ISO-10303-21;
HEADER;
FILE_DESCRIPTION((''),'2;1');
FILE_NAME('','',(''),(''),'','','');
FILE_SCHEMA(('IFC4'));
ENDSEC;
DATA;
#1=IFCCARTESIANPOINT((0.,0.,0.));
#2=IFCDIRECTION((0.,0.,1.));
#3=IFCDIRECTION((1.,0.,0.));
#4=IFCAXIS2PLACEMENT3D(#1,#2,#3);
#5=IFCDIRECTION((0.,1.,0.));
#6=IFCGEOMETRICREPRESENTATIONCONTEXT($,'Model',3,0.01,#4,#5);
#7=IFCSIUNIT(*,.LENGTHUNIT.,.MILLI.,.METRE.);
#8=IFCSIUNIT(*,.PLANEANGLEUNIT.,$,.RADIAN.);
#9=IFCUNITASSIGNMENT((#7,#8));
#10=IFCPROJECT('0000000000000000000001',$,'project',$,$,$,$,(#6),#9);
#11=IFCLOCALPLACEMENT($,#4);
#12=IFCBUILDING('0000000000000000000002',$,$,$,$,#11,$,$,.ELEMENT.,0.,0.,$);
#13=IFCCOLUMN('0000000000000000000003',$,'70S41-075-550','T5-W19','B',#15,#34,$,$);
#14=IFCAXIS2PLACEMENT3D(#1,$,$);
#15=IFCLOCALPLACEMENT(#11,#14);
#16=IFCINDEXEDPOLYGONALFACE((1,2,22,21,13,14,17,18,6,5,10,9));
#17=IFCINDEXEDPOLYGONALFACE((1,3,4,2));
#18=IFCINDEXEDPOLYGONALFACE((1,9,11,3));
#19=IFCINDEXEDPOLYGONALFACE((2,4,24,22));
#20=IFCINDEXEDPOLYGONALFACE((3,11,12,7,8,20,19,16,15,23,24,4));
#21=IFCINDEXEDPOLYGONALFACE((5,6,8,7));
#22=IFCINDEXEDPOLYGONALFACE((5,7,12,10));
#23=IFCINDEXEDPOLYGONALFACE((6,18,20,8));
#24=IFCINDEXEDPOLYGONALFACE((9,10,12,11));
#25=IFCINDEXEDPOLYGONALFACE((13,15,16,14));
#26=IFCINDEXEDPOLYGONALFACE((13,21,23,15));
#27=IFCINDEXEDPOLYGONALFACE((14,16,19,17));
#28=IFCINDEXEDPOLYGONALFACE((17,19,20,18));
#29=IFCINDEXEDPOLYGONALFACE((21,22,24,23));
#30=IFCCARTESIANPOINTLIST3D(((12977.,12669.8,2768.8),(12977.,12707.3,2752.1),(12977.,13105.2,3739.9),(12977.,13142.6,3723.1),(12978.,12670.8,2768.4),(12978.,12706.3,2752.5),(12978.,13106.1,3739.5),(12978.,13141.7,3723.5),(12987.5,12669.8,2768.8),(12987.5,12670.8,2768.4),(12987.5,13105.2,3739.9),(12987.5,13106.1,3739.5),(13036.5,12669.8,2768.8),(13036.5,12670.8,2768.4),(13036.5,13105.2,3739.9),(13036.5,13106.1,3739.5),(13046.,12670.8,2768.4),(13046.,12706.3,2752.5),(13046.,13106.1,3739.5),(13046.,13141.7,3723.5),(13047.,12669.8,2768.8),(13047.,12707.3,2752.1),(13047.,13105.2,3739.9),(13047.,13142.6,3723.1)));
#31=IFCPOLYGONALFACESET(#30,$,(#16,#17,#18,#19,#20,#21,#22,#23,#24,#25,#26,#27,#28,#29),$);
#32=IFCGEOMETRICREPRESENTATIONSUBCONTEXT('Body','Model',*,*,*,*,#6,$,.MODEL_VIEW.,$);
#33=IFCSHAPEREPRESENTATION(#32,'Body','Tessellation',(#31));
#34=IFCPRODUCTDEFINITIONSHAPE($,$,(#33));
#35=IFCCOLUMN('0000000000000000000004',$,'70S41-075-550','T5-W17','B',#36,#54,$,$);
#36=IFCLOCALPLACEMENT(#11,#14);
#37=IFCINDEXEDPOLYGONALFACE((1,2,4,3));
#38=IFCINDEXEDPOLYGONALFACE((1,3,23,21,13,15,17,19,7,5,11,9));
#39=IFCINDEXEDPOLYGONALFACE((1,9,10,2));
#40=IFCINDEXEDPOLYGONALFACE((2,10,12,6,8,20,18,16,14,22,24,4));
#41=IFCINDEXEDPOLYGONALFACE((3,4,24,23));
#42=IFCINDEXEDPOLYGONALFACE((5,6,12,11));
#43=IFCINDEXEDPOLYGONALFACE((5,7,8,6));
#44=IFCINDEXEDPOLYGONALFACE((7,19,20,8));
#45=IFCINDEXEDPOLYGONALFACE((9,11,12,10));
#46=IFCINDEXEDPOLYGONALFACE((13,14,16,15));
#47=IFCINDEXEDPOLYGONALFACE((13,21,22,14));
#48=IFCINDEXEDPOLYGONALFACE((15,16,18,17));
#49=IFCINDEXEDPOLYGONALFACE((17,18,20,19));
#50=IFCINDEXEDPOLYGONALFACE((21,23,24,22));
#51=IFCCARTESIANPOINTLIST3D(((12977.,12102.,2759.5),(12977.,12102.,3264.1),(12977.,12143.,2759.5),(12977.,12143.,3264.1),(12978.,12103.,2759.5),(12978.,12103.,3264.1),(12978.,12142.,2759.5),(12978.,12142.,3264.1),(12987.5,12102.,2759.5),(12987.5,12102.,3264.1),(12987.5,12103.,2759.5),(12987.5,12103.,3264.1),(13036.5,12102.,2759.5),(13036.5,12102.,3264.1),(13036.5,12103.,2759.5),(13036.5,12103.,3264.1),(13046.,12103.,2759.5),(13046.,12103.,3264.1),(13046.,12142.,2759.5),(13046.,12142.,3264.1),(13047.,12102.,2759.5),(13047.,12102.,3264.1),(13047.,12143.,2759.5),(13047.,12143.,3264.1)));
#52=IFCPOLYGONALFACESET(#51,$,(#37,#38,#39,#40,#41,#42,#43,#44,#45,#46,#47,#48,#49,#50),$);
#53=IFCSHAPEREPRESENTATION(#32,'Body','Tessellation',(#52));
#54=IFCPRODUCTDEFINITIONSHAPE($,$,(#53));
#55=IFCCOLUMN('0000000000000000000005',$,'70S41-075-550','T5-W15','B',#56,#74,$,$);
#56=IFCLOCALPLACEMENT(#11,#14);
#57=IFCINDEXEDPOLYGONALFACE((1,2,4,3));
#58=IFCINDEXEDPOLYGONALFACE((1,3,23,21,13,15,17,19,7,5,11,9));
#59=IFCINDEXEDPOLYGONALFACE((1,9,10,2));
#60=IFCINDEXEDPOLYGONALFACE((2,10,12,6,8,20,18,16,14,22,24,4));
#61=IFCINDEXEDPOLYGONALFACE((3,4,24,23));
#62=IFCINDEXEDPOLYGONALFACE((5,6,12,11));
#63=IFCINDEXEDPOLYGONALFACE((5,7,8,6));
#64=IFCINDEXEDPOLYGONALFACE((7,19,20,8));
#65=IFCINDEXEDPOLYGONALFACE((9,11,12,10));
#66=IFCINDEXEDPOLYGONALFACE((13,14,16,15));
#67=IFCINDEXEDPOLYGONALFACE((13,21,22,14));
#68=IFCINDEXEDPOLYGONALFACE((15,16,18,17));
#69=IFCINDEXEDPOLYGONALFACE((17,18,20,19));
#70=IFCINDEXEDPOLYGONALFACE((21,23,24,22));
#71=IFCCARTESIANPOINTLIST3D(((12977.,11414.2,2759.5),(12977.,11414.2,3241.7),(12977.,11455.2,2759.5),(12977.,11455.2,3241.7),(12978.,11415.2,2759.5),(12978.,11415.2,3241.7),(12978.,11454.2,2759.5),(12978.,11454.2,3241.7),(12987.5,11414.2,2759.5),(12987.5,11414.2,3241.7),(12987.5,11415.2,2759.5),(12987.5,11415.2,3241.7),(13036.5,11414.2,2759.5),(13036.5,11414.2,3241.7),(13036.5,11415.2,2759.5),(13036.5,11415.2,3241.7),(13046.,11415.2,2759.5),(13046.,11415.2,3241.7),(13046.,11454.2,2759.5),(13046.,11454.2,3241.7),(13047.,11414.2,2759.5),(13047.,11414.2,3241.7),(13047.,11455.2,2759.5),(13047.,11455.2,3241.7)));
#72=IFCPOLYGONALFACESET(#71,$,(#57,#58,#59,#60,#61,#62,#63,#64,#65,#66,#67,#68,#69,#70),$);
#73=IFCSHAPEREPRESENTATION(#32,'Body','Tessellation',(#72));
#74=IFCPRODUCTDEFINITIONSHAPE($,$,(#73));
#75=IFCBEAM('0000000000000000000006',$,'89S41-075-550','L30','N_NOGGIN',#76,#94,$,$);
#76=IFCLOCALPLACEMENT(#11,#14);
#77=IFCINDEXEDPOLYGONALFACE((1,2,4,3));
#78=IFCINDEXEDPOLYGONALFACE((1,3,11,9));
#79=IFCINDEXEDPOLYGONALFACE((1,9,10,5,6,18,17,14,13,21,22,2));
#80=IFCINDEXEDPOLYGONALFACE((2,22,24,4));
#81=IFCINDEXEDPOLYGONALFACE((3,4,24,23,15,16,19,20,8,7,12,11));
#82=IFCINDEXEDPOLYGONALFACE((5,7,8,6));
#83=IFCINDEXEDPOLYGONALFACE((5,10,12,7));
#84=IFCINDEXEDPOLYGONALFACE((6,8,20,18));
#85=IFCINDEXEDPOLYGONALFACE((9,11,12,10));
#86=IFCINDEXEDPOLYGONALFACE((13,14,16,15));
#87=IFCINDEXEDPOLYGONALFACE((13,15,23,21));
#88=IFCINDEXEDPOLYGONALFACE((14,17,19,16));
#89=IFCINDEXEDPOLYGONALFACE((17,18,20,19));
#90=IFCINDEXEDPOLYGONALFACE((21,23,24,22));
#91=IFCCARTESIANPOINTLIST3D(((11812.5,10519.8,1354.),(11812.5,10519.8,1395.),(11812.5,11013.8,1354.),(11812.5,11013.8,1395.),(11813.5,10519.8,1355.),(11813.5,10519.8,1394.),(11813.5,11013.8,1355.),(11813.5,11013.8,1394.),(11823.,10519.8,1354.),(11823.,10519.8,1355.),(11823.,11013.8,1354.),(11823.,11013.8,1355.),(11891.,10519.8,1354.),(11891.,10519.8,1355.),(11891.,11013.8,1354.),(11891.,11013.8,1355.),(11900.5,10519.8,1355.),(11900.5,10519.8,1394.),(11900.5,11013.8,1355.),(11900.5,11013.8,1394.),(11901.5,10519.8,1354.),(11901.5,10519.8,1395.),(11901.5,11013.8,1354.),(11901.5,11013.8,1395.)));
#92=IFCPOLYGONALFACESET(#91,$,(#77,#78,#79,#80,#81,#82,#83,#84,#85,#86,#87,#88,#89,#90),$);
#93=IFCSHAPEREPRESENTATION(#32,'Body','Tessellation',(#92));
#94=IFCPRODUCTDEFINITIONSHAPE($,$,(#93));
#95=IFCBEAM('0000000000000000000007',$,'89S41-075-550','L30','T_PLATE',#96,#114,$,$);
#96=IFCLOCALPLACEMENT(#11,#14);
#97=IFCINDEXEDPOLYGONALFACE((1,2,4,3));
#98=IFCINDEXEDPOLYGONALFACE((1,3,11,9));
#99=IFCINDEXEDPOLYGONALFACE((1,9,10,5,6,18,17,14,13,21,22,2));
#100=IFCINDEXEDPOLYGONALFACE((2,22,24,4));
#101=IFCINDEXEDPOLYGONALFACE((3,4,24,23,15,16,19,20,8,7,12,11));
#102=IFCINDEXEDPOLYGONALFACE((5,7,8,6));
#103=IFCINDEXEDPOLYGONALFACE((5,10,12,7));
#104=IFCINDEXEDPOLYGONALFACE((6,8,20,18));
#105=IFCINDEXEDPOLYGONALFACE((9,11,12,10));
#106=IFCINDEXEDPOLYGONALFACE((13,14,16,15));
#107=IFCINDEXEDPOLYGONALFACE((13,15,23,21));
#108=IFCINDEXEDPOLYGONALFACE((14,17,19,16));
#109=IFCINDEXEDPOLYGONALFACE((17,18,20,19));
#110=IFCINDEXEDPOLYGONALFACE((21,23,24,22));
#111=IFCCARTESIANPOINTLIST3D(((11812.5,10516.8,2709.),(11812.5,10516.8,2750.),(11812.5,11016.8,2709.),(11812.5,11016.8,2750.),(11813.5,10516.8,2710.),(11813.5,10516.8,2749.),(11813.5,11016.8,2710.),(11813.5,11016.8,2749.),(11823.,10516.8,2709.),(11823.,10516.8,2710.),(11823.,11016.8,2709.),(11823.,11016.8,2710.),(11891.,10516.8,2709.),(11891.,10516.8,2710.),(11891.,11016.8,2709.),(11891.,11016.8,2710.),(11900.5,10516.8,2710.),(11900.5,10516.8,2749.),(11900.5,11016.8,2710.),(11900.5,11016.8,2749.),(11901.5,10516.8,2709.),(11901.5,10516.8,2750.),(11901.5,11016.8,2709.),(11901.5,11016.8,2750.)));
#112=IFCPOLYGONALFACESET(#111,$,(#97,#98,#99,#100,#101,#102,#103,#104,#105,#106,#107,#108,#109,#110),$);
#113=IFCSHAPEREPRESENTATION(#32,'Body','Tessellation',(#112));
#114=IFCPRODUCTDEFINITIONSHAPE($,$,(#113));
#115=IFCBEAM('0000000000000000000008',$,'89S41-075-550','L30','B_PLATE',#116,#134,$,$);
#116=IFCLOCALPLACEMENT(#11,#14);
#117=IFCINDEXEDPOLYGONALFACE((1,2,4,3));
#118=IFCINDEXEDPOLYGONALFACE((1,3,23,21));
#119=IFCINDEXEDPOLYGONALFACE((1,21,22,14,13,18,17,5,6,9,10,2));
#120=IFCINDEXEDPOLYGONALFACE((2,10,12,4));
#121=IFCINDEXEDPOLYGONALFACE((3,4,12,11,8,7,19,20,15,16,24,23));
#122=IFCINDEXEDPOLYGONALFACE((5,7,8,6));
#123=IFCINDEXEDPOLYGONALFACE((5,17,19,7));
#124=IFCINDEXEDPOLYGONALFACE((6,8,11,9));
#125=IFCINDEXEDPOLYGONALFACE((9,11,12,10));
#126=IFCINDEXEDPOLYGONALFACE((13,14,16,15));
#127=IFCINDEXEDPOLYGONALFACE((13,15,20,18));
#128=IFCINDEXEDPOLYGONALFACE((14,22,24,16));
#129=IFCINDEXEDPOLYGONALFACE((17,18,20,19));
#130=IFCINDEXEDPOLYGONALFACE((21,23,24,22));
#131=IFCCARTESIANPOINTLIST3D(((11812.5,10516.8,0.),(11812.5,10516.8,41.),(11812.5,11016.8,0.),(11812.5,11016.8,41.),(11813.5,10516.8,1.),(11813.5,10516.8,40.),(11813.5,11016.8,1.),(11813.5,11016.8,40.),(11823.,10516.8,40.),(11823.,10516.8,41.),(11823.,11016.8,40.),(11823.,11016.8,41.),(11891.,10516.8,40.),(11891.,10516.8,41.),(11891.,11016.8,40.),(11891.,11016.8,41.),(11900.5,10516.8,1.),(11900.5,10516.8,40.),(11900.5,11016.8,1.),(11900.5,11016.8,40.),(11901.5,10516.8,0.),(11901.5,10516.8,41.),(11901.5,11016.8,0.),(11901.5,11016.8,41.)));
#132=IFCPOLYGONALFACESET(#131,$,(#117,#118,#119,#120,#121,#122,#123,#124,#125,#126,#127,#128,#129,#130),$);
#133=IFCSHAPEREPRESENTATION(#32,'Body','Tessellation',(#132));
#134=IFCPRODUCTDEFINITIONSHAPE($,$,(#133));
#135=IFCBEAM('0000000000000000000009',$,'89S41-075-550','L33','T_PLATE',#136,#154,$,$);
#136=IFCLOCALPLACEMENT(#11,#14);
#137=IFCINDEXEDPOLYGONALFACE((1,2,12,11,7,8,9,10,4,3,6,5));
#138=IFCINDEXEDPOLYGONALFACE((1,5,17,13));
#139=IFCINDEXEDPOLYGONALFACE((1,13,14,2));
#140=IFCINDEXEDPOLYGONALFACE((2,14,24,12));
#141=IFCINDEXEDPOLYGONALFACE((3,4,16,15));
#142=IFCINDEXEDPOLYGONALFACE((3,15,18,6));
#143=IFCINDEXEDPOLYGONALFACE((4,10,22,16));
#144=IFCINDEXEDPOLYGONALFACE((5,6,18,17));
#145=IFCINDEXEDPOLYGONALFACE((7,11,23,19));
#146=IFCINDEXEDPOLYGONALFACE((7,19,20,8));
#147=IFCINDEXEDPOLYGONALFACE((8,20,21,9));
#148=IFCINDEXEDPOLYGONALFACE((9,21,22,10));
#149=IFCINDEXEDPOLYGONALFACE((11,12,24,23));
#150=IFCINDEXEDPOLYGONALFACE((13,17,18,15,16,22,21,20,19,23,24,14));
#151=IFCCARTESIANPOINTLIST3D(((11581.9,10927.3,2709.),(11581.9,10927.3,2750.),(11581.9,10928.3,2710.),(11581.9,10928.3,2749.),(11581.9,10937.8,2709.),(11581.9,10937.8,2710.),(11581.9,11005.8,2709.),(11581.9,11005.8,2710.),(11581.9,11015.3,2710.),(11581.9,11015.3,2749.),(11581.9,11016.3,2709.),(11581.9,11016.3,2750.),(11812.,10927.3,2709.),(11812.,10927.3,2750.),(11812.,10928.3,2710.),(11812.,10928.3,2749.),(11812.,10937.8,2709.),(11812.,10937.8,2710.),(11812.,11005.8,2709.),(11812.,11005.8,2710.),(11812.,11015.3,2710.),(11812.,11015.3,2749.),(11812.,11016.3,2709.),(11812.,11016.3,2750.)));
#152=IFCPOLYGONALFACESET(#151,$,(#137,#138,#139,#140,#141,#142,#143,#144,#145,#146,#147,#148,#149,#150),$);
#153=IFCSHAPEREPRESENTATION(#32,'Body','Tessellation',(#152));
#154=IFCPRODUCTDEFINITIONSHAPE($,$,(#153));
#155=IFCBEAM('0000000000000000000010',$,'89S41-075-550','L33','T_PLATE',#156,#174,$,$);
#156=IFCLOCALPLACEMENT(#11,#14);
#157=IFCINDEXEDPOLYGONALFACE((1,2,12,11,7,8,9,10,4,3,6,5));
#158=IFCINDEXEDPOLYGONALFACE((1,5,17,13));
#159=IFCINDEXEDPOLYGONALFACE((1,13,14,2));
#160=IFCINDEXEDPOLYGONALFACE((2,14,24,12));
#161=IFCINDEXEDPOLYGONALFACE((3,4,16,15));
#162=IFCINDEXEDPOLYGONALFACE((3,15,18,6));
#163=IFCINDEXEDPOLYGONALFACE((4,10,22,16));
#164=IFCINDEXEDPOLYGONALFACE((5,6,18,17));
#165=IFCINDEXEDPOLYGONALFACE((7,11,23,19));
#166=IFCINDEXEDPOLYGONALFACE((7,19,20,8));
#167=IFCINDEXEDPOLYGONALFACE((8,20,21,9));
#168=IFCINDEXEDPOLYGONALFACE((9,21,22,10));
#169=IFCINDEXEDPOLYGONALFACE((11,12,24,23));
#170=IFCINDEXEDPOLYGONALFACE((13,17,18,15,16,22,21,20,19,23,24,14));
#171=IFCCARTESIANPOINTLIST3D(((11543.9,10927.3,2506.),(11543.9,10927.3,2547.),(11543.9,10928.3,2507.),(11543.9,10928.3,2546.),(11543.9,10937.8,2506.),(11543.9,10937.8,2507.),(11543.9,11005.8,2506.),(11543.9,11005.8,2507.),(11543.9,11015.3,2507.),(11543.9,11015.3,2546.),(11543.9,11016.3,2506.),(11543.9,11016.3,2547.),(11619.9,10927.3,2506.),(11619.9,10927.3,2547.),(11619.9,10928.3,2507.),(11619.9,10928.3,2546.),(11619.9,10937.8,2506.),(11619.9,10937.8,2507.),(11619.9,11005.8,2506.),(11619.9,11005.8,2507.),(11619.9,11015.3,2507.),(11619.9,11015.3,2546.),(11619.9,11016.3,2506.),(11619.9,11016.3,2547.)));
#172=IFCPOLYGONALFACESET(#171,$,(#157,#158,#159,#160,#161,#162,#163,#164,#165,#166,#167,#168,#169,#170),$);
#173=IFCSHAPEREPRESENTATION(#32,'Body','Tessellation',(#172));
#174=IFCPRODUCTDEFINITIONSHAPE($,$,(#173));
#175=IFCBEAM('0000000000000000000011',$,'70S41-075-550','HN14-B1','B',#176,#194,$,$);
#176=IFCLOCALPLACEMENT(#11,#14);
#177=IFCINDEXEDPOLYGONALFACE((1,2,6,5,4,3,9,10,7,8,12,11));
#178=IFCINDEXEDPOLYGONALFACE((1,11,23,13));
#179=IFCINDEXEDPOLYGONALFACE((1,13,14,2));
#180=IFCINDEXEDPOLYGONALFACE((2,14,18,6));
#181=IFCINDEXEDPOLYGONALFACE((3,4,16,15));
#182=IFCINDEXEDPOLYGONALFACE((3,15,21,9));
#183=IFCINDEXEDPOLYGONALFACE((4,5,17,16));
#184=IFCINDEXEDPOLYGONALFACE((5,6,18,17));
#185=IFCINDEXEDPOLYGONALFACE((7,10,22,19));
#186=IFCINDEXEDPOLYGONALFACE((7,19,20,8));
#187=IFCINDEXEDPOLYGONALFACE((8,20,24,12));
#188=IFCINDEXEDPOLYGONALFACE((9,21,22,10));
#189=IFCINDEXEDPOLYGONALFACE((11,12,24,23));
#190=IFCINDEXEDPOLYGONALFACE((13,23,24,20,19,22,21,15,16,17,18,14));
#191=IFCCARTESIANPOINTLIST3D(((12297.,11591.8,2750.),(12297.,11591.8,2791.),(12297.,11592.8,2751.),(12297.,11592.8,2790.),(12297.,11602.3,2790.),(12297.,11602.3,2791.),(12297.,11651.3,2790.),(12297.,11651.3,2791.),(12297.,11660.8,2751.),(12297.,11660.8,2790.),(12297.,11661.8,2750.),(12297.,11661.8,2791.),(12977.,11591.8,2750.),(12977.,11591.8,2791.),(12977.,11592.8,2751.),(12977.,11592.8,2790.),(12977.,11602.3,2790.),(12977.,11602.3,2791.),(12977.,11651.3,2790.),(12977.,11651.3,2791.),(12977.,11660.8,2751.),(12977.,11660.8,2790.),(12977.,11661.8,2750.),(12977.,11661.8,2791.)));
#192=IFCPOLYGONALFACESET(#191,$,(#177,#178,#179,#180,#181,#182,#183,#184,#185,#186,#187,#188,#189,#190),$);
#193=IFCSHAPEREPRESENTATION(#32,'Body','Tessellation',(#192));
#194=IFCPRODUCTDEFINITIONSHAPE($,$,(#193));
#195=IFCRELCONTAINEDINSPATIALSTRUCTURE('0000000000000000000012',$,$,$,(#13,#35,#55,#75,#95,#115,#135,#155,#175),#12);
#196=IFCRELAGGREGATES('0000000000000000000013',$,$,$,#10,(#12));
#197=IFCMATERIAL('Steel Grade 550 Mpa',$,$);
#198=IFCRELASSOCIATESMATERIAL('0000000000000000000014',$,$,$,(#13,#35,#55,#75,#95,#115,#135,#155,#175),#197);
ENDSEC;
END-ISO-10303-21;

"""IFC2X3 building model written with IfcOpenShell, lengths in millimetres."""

from ifc_helpers import new_model, si_unit, direction, frame, origin, origin_with_axes, origin_2d_with_axis, place, context, subcontext, project, spatial, c_section, extrude, source, transform, mapped, material, element, save


model = new_model("IFC2X3")

# Units and contexts
model_context = context("Model", 3, precision=0.01, world=origin_with_axes(), true_north=direction((0.0, 1.0, 0.0)))
body_context = subcontext(model_context, "Body", "Model", "MODEL_VIEW")
ifc_project = project(units=[si_unit("LENGTHUNIT", "METRE", prefix="MILLI"), si_unit("PLANEANGLEUNIT", "RADIAN")], contexts=[model_context])

# Building
building_placement = place(None, origin_with_axes())
building = spatial("IfcBuilding", under=ifc_project, at=building_placement, CompositionType="ELEMENT", ElevationOfRefHeight=0.0, ElevationOfTerrain=0.0)

# Columns
ifc_material = material(Name="Steel Grade 550 Mpa")
shared_shape_1 = source(origin(), body_context, "Body", "SweptSolid", [
    extrude(c_section(Depth=70.0, Width=41.0, WallThickness=1.0, Girth=10.5, at=origin_2d_with_axis()), origin_with_axes(), (0.0, 0.0, 1.0), 1064.1),
])
column_1_placement = place(None, frame((13012.0, 12688.5, 2760.5), z_axis=(-0.000001, 0.409121, 0.91248), x_axis=(0.000003, -0.91248, 0.409121)))
element("IfcColumn", 1, at=column_1_placement, inside=building, material=ifc_material, Name="70S41-075-550", Description="T5-W19", ObjectType="B", context=body_context, shape_type="MappedRepresentation", body=[
    mapped(shared_shape_1, transform((0.0, 0.0, 0.0), scale=1.0)),
])
shared_shape_2 = source(origin(), body_context, "Body", "SweptSolid", [
    extrude(c_section(Depth=70.0, Width=41.0, WallThickness=1.0, Girth=10.5, at=origin_2d_with_axis()), origin_with_axes(), (0.0, 0.0, 1.0), 504.6),
])
column_2_placement = place(None, frame((13012.0, 12122.5, 2759.5), z_axis=(0.0, 0.0, 1.0), x_axis=(0.000004, -1.0, 0.0)))
element("IfcColumn", 2, at=column_2_placement, inside=building, material=ifc_material, Name="70S41-075-550", Description="T5-W17", ObjectType="B", context=body_context, shape_type="MappedRepresentation", body=[
    mapped(shared_shape_2, transform((0.0, 0.0, 0.0), scale=1.0)),
])
shared_shape_3 = source(origin(), body_context, "Body", "SweptSolid", [
    extrude(c_section(Depth=70.0, Width=41.0, WallThickness=1.0, Girth=10.5, at=origin_2d_with_axis()), origin_with_axes(), (0.0, 0.0, 1.0), 482.2),
])
column_3_placement = place(None, frame((13012.0, 11434.7, 2759.5), z_axis=(0.0, 0.0, 1.0), x_axis=(0.000004, -1.0, 0.0)))
element("IfcColumn", 3, at=column_3_placement, inside=building, material=ifc_material, Name="70S41-075-550", Description="T5-W15", ObjectType="B", context=body_context, shape_type="MappedRepresentation", body=[
    mapped(shared_shape_3, transform((0.0, 0.0, 0.0), scale=1.0)),
])

# Beams
shared_shape_4 = source(origin(), body_context, "Body", "SweptSolid", [
    extrude(c_section(Depth=89.0, Width=41.0, WallThickness=1.0, Girth=10.5, at=origin_2d_with_axis()), origin_with_axes(), (0.0, 0.0, 1.0), 494.0),
])
beam_1_placement = place(None, frame((11857.0, 11013.8, 1374.5), z_axis=(0.0, -1.0, 0.0), x_axis=(0.0, 0.0, -1.0)))
element("IfcBeam", 4, at=beam_1_placement, inside=building, material=ifc_material, Name="89S41-075-550", Description="L30", ObjectType="N_NOGGIN", context=body_context, shape_type="MappedRepresentation", body=[
    mapped(shared_shape_4, transform((0.0, 0.0, 0.0), scale=1.0)),
])
shared_shape_5 = source(origin(), body_context, "Body", "SweptSolid", [
    extrude(c_section(Depth=89.0, Width=41.0, WallThickness=1.0, Girth=10.5, at=origin_2d_with_axis()), origin_with_axes(), (0.0, 0.0, 1.0), 500.0),
])
beam_2_placement = place(None, frame((11857.0, 11016.8, 2729.5), z_axis=(0.0, -1.0, 0.0), x_axis=(0.0, 0.0, -1.0)))
element("IfcBeam", 5, at=beam_2_placement, inside=building, material=ifc_material, Name="89S41-075-550", Description="L30", ObjectType="T_PLATE", context=body_context, shape_type="MappedRepresentation", body=[
    mapped(shared_shape_5, transform((0.0, 0.0, 0.0), scale=1.0)),
])
shared_shape_6 = source(origin(), body_context, "Body", "SweptSolid", [
    extrude(c_section(Depth=89.0, Width=41.0, WallThickness=1.0, Girth=10.5, at=origin_2d_with_axis()), origin_with_axes(), (0.0, 0.0, 1.0), 500.0),
])
beam_3_placement = place(None, frame((11857.0, 11016.8, 20.5), z_axis=(0.0, -1.0, 0.0), x_axis=(0.0, 0.0, 1.0)))
element("IfcBeam", 6, at=beam_3_placement, inside=building, material=ifc_material, Name="89S41-075-550", Description="L30", ObjectType="B_PLATE", context=body_context, shape_type="MappedRepresentation", body=[
    mapped(shared_shape_6, transform((0.0, 0.0, 0.0), scale=1.0)),
])
shared_shape_7 = source(origin(), body_context, "Body", "SweptSolid", [
    extrude(c_section(Depth=89.0, Width=41.0, WallThickness=1.0, Girth=10.5, at=origin_2d_with_axis()), origin_with_axes(), (0.0, 0.0, 1.0), 230.1),
])
beam_4_placement = place(None, frame((11581.9, 10971.8, 2729.5), z_axis=(1.0, 0.0, 0.0), x_axis=(0.0, 0.0, -1.0)))
element("IfcBeam", 7, at=beam_4_placement, inside=building, material=ifc_material, Name="89S41-075-550", Description="L33", ObjectType="T_PLATE", context=body_context, shape_type="MappedRepresentation", body=[
    mapped(shared_shape_7, transform((0.0, 0.0, 0.0), scale=1.0)),
])
shared_shape_8 = source(origin(), body_context, "Body", "SweptSolid", [
    extrude(c_section(Depth=89.0, Width=41.0, WallThickness=1.0, Girth=10.5, at=origin_2d_with_axis()), origin_with_axes(), (0.0, 0.0, 1.0), 76.0),
])
beam_5_placement = place(None, frame((11543.9, 10971.8, 2526.5), z_axis=(1.0, 0.0, 0.0), x_axis=(0.0, 0.0, -1.0)))
element("IfcBeam", 8, at=beam_5_placement, inside=building, material=ifc_material, Name="89S41-075-550", Description="L33", ObjectType="T_PLATE", context=body_context, shape_type="MappedRepresentation", body=[
    mapped(shared_shape_8, transform((0.0, 0.0, 0.0), scale=1.0)),
])
shared_shape_9 = source(origin(), body_context, "Body", "SweptSolid", [
    extrude(c_section(Depth=70.0, Width=41.0, WallThickness=1.0, Girth=10.5, at=origin_2d_with_axis()), origin_with_axes(), (0.0, 0.0, 1.0), 680.0),
])
beam_6_placement = place(None, frame((12297.0, 11626.8, 2770.5), z_axis=(1.0, 0.000004, 0.0), x_axis=(0.0, 0.0, 1.0)))
element("IfcBeam", 9, at=beam_6_placement, inside=building, material=ifc_material, Name="70S41-075-550", Description="HN14-B1", ObjectType="B", context=body_context, shape_type="MappedRepresentation", body=[
    mapped(shared_shape_9, transform((0.0, 0.0, 0.0), scale=1.0)),
])

save(model, "model.ifc")
